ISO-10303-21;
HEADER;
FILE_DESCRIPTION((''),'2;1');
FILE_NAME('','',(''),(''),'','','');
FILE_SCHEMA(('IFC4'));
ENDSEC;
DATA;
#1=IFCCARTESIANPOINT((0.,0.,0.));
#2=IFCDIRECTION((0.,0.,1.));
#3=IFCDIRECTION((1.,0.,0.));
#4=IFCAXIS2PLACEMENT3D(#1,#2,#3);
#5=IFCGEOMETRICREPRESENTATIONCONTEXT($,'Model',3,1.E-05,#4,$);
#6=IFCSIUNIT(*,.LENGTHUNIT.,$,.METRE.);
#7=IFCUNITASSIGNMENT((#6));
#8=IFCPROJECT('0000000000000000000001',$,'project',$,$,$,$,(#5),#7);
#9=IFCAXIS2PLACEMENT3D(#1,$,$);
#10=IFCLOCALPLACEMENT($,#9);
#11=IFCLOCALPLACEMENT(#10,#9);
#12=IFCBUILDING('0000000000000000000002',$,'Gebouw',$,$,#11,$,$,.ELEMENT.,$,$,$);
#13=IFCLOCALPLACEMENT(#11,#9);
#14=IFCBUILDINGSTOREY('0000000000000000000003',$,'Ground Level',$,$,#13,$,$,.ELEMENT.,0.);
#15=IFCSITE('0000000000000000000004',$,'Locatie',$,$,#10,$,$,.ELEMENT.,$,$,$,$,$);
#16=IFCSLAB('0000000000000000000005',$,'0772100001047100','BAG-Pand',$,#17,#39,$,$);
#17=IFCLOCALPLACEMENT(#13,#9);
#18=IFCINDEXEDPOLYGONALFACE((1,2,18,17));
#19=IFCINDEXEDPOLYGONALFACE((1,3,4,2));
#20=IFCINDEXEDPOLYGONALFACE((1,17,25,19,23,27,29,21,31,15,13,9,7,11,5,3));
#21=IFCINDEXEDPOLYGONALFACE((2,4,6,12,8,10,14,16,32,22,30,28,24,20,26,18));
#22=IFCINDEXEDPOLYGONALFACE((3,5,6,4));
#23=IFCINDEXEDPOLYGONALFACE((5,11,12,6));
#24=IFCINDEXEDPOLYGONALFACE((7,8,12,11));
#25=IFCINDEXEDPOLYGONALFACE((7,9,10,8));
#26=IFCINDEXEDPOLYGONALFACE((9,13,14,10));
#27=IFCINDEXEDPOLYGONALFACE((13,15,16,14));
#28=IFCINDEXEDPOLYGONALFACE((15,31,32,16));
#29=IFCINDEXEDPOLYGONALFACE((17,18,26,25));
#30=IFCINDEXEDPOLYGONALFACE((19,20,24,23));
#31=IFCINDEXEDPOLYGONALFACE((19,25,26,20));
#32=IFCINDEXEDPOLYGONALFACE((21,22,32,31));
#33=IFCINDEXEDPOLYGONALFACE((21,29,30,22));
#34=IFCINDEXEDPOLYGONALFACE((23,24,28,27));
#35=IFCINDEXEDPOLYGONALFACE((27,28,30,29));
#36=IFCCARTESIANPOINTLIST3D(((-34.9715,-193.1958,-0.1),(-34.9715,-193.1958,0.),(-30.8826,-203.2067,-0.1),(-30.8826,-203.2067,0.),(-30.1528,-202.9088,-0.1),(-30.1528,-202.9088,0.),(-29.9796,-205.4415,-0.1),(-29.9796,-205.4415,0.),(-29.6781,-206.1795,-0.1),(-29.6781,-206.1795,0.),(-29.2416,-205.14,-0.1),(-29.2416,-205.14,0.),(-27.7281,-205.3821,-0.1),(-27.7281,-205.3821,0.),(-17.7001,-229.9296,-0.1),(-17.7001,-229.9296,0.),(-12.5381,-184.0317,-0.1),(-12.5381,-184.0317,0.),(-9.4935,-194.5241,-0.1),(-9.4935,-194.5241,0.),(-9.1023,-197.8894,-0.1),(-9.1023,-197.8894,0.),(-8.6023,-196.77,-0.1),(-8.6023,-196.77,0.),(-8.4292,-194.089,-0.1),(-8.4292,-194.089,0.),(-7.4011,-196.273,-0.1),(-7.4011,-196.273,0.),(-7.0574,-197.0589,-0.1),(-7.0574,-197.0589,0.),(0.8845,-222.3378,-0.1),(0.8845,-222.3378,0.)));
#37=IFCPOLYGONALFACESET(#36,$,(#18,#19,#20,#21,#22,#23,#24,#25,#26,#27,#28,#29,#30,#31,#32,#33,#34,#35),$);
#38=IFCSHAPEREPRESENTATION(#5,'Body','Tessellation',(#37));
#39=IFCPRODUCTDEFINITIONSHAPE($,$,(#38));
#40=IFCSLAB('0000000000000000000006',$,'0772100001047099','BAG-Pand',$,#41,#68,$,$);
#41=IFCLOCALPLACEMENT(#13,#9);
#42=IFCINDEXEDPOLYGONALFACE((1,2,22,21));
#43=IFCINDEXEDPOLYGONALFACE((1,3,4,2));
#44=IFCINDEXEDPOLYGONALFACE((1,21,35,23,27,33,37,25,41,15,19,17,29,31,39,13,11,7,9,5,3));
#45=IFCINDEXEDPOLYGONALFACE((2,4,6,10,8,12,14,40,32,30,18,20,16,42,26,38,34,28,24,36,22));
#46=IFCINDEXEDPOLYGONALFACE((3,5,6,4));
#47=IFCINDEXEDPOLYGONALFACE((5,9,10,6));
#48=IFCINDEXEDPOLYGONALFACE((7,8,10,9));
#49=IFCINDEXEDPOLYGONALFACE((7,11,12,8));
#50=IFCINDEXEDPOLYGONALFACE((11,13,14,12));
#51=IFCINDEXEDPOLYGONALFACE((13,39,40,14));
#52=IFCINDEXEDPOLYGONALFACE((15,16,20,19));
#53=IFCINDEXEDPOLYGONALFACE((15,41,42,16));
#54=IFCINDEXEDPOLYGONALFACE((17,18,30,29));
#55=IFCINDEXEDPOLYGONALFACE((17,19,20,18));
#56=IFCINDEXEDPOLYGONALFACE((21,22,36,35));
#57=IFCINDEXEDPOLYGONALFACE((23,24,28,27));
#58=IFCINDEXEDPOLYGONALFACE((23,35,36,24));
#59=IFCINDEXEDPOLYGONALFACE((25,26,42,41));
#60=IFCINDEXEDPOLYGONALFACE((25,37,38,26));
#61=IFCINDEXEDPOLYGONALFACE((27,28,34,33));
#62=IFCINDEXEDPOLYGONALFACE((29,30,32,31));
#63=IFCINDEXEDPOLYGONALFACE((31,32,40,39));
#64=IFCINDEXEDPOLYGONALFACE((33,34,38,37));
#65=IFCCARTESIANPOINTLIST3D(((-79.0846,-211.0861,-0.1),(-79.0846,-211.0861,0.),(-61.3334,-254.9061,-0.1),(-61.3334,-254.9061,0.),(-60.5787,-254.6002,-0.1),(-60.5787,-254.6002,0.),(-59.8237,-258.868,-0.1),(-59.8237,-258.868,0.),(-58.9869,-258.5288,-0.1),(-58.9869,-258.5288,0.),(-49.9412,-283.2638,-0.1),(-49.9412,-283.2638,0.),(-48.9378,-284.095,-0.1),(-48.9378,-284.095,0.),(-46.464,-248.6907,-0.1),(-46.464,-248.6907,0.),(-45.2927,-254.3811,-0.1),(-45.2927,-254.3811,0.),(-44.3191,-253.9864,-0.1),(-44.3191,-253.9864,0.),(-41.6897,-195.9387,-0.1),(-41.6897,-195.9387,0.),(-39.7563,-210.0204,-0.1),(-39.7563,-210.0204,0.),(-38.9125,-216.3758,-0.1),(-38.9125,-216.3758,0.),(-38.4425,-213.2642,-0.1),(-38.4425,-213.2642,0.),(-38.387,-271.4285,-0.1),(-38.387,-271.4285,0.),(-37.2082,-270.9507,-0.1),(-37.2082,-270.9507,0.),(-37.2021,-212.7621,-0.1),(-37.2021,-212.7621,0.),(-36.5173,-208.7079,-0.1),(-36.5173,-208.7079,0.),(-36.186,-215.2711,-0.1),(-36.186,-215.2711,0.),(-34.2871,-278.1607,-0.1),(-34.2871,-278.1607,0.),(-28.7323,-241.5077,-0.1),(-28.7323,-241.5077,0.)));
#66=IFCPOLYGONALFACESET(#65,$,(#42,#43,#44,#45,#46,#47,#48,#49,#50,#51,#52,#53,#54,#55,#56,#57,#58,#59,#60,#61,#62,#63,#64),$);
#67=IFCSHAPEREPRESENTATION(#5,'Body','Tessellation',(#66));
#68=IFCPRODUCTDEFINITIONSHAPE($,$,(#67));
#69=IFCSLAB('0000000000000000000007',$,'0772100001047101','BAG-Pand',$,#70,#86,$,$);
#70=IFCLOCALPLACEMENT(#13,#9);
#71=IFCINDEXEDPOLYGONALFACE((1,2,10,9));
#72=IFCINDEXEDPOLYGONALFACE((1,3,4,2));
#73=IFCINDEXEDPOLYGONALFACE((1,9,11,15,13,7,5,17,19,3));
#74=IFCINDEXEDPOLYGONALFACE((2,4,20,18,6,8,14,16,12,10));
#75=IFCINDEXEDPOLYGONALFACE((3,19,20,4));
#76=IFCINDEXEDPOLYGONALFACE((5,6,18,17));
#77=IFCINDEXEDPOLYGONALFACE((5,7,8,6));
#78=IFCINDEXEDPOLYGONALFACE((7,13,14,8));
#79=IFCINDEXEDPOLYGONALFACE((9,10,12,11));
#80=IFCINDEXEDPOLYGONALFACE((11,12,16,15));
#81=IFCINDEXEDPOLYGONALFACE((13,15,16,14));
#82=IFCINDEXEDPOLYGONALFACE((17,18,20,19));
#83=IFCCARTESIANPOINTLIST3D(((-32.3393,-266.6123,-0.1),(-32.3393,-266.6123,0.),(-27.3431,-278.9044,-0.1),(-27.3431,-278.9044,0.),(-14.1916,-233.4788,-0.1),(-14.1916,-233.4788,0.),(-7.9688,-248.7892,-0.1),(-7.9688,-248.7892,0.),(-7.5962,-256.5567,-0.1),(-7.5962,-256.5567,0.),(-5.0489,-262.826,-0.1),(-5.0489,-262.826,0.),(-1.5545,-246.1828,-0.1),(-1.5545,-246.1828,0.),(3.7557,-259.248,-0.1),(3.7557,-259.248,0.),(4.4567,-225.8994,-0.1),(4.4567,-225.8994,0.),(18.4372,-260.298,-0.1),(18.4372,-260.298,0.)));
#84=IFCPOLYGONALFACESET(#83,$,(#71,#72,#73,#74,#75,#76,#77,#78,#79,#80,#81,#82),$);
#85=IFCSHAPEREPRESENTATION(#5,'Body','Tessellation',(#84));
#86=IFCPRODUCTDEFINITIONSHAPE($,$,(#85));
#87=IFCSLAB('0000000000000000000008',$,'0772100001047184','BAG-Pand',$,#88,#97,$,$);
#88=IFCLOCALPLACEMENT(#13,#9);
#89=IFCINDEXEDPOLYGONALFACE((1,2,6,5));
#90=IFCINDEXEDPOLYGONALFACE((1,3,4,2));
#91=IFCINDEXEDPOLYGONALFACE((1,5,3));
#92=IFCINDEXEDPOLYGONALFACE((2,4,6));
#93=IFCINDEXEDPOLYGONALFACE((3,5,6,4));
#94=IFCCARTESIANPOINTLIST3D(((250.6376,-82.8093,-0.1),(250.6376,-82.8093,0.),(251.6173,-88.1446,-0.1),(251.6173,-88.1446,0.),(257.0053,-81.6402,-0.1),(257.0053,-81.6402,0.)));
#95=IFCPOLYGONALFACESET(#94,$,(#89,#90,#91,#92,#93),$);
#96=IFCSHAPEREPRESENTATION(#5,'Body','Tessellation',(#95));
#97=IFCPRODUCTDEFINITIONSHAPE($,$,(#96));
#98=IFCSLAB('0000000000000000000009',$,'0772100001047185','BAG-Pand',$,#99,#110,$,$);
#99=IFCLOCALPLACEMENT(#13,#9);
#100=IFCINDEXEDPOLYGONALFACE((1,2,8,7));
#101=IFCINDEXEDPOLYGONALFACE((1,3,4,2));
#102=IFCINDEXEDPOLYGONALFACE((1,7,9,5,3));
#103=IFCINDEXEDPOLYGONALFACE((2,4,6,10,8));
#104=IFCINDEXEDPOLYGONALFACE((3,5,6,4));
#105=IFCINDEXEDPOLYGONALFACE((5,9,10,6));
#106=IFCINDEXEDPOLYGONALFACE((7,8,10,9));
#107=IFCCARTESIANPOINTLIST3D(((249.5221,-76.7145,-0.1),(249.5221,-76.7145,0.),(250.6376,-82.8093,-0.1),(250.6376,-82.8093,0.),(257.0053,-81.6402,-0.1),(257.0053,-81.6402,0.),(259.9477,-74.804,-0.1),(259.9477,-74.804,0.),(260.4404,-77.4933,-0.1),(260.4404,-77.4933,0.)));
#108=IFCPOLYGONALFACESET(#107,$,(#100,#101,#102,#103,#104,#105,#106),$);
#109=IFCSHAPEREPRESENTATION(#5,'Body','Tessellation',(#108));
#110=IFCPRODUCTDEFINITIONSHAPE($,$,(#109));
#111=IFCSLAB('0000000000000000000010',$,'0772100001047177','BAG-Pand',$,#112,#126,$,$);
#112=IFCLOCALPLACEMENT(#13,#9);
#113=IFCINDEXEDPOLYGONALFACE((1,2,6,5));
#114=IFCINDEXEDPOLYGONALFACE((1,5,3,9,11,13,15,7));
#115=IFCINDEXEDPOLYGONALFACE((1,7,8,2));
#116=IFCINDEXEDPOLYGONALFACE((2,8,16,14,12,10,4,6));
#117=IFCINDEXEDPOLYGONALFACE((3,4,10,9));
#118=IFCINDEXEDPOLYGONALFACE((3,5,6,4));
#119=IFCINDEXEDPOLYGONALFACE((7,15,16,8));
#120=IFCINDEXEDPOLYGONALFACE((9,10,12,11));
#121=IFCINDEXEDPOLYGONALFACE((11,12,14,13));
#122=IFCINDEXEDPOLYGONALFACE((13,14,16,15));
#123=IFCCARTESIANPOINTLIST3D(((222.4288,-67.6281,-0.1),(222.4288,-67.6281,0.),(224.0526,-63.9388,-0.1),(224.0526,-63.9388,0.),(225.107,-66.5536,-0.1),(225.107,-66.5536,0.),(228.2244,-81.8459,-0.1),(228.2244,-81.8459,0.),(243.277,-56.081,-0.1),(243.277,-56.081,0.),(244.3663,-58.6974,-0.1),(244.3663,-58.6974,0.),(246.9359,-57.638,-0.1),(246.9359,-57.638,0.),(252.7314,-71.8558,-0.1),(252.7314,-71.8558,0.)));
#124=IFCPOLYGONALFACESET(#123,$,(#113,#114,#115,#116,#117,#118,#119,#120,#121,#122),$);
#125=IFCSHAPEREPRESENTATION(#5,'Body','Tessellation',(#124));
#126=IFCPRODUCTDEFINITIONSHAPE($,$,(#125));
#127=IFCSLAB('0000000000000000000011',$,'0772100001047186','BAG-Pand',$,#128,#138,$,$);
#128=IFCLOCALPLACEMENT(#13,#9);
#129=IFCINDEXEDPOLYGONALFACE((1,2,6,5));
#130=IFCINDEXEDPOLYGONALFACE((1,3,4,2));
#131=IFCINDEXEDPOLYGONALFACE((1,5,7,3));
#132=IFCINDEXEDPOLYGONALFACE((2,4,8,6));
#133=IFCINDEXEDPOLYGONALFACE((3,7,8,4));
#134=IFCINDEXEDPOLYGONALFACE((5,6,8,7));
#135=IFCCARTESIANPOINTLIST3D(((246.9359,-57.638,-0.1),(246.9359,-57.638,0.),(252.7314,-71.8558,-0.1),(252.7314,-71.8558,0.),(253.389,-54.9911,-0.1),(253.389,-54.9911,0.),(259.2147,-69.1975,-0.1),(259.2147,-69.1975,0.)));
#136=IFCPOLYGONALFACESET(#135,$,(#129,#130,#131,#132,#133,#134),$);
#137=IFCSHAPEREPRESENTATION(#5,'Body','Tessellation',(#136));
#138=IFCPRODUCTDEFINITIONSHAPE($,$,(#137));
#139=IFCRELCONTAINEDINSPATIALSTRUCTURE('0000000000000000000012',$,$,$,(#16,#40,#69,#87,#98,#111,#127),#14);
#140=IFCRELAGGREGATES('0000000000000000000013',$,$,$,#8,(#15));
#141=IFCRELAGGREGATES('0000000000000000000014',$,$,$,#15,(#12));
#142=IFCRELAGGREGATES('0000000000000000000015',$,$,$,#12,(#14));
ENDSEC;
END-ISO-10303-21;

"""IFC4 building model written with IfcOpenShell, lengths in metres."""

from ifc_helpers import new_model, si_unit, frame, origin, origin_with_axes, place, context, project, spatial, polyline, outline, extrude, element, save


model = new_model("IFC4")

# Units and contexts
model_context = context("Model", 3, precision=1e-05, world=origin_with_axes())
ifc_project = project(units=[si_unit("LENGTHUNIT", "METRE")], contexts=[model_context])

# Site, building, storey
site_placement = place(None, origin())
site = spatial("IfcSite", under=ifc_project, at=site_placement, Name="Locatie", CompositionType="ELEMENT")
building_placement = place(site_placement, origin())
building = spatial("IfcBuilding", under=site, at=building_placement, Name="Gebouw", CompositionType="ELEMENT")
storey_placement = place(building_placement, origin())
storey = spatial("IfcBuildingStorey", under=building, at=storey_placement, Name="Ground Level", CompositionType="ELEMENT", Elevation=0.0)

# Slabs
slab_1_placement = place(storey_placement, origin())
element("IfcSlab", 1, at=slab_1_placement, inside=storey, Name="0772100001047100", Description="BAG-Pand", context=model_context, shape_type="SweptSolid", body=[
    extrude(outline(polyline([(-27.7281, -205.3821), (-29.6781, -206.1795), (-29.9796, -205.4415), (-29.2416, -205.14), (-30.1528, -202.9088), (-30.8826, -203.2067), (-34.9715, -193.1958), (-12.5381, -184.0317), (-8.4292, -194.089), (-9.4935, -194.5241), (-8.6023, -196.77), (-7.4011, -196.273), (-7.0574, -197.0589), (-9.1023, -197.8894), (0.8845, -222.3378), (-17.7001, -229.9296), (-27.7281, -205.3821)])), frame((0.0, 0.0, -0.1), z_axis=(0.0, 0.0, 1.0), x_axis=(1.0, 0.0, 0.0)), (0.0, 0.0, 1.0), 0.1),
])
slab_2_placement = place(storey_placement, origin())
element("IfcSlab", 2, at=slab_2_placement, inside=storey, Name="0772100001047099", Description="BAG-Pand", context=model_context, shape_type="SweptSolid", body=[
    extrude(outline(polyline([(-59.8237, -258.868), (-58.9869, -258.5288), (-60.5787, -254.6002), (-61.3334, -254.9061), (-79.0846, -211.0861), (-41.6897, -195.9387), (-36.5173, -208.7079), (-39.7563, -210.0204), (-38.4425, -213.2642), (-37.2021, -212.7621), (-36.186, -215.2711), (-38.9125, -216.3758), (-28.7323, -241.5077), (-46.464, -248.6907), (-44.3191, -253.9864), (-45.2927, -254.3811), (-38.387, -271.4285), (-37.2082, -270.9507), (-34.2871, -278.1607), (-48.9378, -284.095), (-49.9412, -283.2638), (-59.8237, -258.868)])), frame((0.0, 0.0, -0.1), z_axis=(0.0, 0.0, 1.0), x_axis=(1.0, 0.0, 0.0)), (0.0, 0.0, 1.0), 0.1),
])
slab_3_placement = place(storey_placement, origin())
element("IfcSlab", 3, at=slab_3_placement, inside=storey, Name="0772100001047101", Description="BAG-Pand", context=model_context, shape_type="SweptSolid", body=[
    extrude(outline(polyline([(-32.3393, -266.6123), (-7.5962, -256.5567), (-5.0489, -262.826), (3.7557, -259.248), (-1.5545, -246.1828), (-7.9688, -248.7892), (-14.1916, -233.4788), (4.4567, -225.8994), (18.4372, -260.298), (-27.3431, -278.9044), (-32.3393, -266.6123)])), frame((0.0, 0.0, -0.1), z_axis=(0.0, 0.0, 1.0), x_axis=(1.0, 0.0, 0.0)), (0.0, 0.0, 1.0), 0.1),
])
slab_4_placement = place(storey_placement, origin())
element("IfcSlab", 4, at=slab_4_placement, inside=storey, Name="0772100001047184", Description="BAG-Pand", context=model_context, shape_type="SweptSolid", body=[
    extrude(outline(polyline([(250.6376, -82.8093), (257.0053, -81.6402), (251.6173, -88.1446), (250.6376, -82.8093)])), frame((0.0, 0.0, -0.1), z_axis=(0.0, 0.0, 1.0), x_axis=(1.0, 0.0, 0.0)), (0.0, 0.0, 1.0), 0.1),
])
slab_5_placement = place(storey_placement, origin())
element("IfcSlab", 5, at=slab_5_placement, inside=storey, Name="0772100001047185", Description="BAG-Pand", context=model_context, shape_type="SweptSolid", body=[
    extrude(outline(polyline([(250.6376, -82.8093), (249.5221, -76.7145), (259.9477, -74.804), (260.4404, -77.4933), (257.0053, -81.6402), (250.6376, -82.8093)])), frame((0.0, 0.0, -0.1), z_axis=(0.0, 0.0, 1.0), x_axis=(1.0, 0.0, 0.0)), (0.0, 0.0, 1.0), 0.1),
])
slab_6_placement = place(storey_placement, origin())
element("IfcSlab", 6, at=slab_6_placement, inside=storey, Name="0772100001047177", Description="BAG-Pand", context=model_context, shape_type="SweptSolid", body=[
    extrude(outline(polyline([(222.4288, -67.6281), (225.107, -66.5536), (224.0526, -63.9388), (243.277, -56.081), (244.3663, -58.6974), (246.9359, -57.638), (252.7314, -71.8558), (228.2244, -81.8459), (222.4288, -67.6281)])), frame((0.0, 0.0, -0.1), z_axis=(0.0, 0.0, 1.0), x_axis=(1.0, 0.0, 0.0)), (0.0, 0.0, 1.0), 0.1),
])
slab_7_placement = place(storey_placement, origin())
element("IfcSlab", 7, at=slab_7_placement, inside=storey, Name="0772100001047186", Description="BAG-Pand", context=model_context, shape_type="SweptSolid", body=[
    extrude(outline(polyline([(246.9359, -57.638), (253.389, -54.9911), (259.2147, -69.1975), (252.7314, -71.8558), (246.9359, -57.638)])), frame((0.0, 0.0, -0.1), z_axis=(0.0, 0.0, 1.0), x_axis=(1.0, 0.0, 0.0)), (0.0, 0.0, 1.0), 0.1),
])

save(model, "model.ifc")
